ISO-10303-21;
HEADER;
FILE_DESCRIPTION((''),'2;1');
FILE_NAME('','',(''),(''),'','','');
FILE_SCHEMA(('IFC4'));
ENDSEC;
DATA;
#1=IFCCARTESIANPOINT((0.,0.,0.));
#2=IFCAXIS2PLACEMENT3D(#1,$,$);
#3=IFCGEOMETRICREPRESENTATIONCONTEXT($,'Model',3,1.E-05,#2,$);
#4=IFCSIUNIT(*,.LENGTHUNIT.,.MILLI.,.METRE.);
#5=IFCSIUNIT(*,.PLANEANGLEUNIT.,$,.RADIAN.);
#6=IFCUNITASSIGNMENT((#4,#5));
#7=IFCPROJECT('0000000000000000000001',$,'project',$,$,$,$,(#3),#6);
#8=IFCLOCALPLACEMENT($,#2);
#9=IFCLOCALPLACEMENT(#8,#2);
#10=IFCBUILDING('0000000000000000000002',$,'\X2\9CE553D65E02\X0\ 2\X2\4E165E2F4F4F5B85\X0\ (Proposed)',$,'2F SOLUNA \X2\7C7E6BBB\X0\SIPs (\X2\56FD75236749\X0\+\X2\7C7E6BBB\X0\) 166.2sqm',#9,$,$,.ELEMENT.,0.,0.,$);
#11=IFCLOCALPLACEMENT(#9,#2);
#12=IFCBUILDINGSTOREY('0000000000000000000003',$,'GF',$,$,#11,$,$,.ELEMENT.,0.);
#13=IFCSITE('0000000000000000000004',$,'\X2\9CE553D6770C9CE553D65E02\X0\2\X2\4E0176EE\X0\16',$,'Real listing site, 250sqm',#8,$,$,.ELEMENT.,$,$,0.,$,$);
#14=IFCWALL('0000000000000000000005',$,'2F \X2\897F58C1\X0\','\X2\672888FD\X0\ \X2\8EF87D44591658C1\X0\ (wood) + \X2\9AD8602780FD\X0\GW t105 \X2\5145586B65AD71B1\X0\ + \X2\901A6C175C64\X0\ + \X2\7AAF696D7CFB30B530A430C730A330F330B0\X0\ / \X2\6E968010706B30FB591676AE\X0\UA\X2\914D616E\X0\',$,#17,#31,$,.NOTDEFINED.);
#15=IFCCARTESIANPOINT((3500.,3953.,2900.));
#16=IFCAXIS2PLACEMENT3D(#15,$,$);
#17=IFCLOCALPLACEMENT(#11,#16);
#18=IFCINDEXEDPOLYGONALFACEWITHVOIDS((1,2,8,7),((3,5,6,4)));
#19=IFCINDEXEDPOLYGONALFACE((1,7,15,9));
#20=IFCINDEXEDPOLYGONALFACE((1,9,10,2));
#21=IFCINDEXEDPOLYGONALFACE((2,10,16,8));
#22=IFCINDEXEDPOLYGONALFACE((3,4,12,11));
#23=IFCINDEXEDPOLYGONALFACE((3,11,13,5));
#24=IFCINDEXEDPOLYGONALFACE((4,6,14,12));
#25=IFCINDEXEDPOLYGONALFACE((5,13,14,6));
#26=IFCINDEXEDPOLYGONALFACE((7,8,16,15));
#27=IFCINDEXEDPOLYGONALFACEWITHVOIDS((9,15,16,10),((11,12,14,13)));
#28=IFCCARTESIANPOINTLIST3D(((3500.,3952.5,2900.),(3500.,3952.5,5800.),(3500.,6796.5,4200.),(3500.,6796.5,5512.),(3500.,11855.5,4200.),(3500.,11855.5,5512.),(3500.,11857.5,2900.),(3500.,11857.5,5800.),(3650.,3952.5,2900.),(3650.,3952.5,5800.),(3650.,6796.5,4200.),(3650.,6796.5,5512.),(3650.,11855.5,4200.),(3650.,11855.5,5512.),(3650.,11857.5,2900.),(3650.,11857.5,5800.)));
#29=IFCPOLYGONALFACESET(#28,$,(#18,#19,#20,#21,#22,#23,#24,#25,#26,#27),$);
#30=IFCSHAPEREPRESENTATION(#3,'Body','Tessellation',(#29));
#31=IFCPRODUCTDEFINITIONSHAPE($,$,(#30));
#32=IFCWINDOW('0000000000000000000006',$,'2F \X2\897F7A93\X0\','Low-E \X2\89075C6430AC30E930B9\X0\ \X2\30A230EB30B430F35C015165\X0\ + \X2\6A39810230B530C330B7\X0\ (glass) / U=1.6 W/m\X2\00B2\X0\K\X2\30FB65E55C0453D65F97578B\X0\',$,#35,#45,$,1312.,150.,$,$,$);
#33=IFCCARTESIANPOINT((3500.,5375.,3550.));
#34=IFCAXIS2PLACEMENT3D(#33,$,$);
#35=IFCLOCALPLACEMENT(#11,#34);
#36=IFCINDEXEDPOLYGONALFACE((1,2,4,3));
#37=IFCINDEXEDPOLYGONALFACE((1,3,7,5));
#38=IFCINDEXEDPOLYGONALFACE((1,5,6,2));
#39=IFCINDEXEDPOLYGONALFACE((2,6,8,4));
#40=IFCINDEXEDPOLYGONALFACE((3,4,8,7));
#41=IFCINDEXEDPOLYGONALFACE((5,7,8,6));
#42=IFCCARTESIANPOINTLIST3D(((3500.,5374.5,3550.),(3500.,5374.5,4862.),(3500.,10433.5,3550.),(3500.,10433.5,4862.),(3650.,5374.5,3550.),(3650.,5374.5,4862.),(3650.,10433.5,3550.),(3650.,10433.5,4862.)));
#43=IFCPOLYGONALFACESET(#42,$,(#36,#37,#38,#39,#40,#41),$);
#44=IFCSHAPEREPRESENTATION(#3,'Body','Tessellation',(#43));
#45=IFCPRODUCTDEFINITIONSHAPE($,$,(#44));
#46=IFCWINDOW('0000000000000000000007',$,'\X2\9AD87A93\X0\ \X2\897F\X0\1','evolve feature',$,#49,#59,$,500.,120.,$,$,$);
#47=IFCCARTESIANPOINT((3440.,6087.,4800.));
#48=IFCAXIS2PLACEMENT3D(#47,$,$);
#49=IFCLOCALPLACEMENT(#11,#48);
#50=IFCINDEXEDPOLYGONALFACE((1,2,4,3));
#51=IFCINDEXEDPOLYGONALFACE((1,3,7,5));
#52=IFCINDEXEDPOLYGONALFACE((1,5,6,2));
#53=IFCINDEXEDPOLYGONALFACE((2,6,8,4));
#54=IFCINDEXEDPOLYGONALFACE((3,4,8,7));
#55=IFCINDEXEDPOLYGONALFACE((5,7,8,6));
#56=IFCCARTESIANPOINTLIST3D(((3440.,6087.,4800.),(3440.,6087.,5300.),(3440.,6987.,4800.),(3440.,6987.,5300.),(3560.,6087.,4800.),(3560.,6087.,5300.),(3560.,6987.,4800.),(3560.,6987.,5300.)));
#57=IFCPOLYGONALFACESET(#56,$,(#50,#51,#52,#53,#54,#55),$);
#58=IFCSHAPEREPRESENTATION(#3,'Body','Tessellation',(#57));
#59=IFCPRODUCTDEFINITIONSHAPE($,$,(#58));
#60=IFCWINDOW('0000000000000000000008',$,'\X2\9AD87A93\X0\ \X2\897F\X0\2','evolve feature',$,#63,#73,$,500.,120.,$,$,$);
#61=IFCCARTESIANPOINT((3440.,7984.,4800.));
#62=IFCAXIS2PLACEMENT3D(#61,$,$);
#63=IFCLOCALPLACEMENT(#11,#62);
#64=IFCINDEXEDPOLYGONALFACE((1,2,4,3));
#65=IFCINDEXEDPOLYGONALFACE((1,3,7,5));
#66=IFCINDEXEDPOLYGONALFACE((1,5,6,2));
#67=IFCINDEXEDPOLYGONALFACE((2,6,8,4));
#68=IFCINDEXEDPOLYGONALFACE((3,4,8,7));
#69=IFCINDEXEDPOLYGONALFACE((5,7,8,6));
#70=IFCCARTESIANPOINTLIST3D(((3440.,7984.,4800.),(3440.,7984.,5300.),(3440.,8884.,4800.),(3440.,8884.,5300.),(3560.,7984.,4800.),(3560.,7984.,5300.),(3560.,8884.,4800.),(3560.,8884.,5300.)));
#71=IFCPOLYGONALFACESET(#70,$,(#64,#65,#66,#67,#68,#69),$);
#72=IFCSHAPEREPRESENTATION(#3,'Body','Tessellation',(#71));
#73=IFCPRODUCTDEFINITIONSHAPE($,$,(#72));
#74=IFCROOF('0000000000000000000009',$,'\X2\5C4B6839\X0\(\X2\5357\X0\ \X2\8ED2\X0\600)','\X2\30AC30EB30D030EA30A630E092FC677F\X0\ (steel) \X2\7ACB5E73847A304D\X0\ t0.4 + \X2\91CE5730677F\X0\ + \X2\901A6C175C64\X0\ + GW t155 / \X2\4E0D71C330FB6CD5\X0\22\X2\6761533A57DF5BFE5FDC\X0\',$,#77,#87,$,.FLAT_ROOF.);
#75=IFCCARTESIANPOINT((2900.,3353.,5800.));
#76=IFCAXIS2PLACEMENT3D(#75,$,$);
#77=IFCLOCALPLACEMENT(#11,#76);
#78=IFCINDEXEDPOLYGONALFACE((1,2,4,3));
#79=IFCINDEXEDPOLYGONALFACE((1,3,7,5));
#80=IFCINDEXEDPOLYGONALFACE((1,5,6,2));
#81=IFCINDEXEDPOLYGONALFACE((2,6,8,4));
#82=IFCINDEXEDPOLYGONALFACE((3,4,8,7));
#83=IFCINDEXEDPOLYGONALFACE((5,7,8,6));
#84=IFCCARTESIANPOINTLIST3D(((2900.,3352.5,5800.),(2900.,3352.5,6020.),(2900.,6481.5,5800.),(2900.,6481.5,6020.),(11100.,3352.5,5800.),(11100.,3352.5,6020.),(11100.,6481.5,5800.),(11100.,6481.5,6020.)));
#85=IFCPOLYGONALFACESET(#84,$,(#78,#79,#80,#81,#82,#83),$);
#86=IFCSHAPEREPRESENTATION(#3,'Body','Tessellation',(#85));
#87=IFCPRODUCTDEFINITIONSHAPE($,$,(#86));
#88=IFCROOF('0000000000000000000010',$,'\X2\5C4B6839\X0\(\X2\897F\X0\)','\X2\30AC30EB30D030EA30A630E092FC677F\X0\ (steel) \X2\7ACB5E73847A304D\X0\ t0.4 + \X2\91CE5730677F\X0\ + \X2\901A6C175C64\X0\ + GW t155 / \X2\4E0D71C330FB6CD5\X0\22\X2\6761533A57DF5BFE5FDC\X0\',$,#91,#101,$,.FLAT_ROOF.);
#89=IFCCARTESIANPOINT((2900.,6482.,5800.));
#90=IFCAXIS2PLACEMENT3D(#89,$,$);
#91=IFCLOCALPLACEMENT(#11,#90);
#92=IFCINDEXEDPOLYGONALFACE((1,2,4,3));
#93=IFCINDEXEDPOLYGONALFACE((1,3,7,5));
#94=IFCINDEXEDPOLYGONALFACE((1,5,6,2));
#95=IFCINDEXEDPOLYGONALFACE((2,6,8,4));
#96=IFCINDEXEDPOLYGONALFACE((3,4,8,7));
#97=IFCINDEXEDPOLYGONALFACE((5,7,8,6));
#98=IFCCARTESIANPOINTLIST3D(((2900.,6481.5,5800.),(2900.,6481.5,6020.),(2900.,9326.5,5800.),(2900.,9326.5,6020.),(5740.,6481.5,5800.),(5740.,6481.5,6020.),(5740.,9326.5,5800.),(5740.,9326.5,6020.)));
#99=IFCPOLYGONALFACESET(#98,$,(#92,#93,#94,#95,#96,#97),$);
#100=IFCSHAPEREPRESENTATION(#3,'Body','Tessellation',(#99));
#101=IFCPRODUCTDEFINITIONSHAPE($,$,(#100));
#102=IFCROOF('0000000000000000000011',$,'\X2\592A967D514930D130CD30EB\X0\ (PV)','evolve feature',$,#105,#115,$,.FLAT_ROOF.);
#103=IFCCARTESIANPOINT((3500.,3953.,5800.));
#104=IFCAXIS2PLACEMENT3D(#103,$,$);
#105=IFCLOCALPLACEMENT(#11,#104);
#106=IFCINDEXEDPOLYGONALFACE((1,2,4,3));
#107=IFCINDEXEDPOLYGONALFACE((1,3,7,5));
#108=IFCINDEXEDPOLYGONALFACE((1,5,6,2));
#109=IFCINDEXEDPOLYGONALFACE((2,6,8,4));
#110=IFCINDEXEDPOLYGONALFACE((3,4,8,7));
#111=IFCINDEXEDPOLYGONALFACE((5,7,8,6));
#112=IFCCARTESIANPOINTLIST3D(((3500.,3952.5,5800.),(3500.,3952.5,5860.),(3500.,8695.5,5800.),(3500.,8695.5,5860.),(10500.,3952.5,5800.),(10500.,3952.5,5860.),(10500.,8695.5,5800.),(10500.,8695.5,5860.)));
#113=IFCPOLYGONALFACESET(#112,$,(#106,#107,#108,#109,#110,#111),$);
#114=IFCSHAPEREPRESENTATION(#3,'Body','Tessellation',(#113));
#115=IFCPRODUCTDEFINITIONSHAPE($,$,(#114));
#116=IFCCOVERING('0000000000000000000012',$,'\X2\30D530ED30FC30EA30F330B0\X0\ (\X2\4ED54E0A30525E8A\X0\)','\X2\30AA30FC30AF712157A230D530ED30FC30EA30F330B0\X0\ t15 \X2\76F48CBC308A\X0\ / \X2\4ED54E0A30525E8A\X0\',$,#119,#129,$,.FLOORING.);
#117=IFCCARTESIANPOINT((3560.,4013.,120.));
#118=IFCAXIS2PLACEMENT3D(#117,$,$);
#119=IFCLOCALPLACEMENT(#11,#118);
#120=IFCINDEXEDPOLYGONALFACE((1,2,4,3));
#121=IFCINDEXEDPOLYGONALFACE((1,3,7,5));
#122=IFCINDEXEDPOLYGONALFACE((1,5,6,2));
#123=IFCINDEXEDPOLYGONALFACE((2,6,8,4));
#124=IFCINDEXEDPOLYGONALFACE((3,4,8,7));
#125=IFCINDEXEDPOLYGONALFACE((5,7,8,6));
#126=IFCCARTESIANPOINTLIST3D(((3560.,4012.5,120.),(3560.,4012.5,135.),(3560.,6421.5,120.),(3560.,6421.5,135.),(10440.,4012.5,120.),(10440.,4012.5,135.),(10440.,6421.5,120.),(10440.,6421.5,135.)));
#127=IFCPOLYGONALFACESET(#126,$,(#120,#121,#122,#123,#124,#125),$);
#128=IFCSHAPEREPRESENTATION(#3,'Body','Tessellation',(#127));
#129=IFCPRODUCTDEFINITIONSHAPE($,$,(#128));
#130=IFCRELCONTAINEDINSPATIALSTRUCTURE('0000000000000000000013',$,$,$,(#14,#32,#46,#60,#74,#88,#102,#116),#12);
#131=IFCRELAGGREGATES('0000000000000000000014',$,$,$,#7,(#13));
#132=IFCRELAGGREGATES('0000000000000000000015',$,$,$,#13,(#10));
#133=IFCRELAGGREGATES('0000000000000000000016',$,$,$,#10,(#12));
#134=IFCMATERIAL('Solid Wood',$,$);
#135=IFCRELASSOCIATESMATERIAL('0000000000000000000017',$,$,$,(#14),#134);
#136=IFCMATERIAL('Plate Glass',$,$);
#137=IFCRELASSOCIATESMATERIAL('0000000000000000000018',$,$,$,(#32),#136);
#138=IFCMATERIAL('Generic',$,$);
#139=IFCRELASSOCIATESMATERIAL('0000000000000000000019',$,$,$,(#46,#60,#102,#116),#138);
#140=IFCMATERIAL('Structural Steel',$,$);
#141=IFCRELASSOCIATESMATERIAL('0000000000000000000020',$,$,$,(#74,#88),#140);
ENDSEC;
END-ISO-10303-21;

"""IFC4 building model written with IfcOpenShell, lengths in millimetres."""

from ifc_helpers import new_model, si_unit, frame, frame_2d, origin, place, context, project, spatial, rectangle, extrude, material, element, fill, save


model = new_model("IFC4")

# Units and contexts
model_context = context("Model", 3, precision=1e-05, world=origin())
ifc_project = project(units=[si_unit("LENGTHUNIT", "METRE", prefix="MILLI"), si_unit("PLANEANGLEUNIT", "RADIAN")], contexts=[model_context])

# Site, building, storey
site_placement = place(None, origin())
site = spatial("IfcSite", under=ifc_project, at=site_placement, Name="鳥取県鳥取市2丁目16", ObjectType="Real listing site, 250sqm", CompositionType="ELEMENT", RefElevation=0.0)
building_placement = place(site_placement, origin())
building = spatial("IfcBuilding", under=site, at=building_placement, Name="鳥取市 2世帯住宅 (Proposed)", ObjectType="2F SOLUNA 籾殻SIPs (国産杉+籾殻) 166.2sqm", CompositionType="ELEMENT", ElevationOfRefHeight=0.0, ElevationOfTerrain=0.0)
storey_placement = place(building_placement, origin())
storey = spatial("IfcBuildingStorey", under=building, at=storey_placement, Name="GF", CompositionType="ELEMENT", Elevation=0.0)

# Shared definitions
ifc_material_1 = material(Name="Solid Wood")
ifc_material_2 = material(Name="Generic")

# Shared definitions
ifc_material_3 = material(Name="Plate Glass")

# Wall, openings, windows
wall_1_placement = place(storey_placement, frame((3500.0, 3953.0, 2900.0)))
wall_1 = element("IfcWall", 1, at=wall_1_placement, inside=storey, material=ifc_material_1, Name="2F 西壁", Description="木製 軸組外壁 (wood) + 高性能GW t105 充填断熱 + 通気層 + 窯業系サイディング / 準耐火・外皮UA配慮", PredefinedType="NOTDEFINED", context=model_context, shape_type="SweptSolid", body=[
    extrude(rectangle(XDim=150.0, YDim=7905.0, at=frame_2d((75.0, 3952.0))), frame((3500.0, 3953.0, 2900.0)), (0.0, 0.0, 1.0), 2900.0),
])
opening_1_placement = place(storey_placement, frame((3500.0, 5375.0, 3550.0)))
opening_1 = element("IfcOpeningElement", 2, at=opening_1_placement, cuts=wall_1, PredefinedType="NOTDEFINED", context=model_context, shape_type="SweptSolid", body=[
    extrude(rectangle(XDim=150.0, YDim=5059.0, at=frame_2d((75.0, 2529.0))), frame((3500.0, 5375.0, 3550.0)), (0.0, 0.0, 1.0), 1312.0),
])
opening_2_placement = place(storey_placement, frame((3440.0, 6087.0, 4800.0)))
opening_2 = element("IfcOpeningElement", 3, at=opening_2_placement, cuts=wall_1, PredefinedType="NOTDEFINED", context=model_context, shape_type="SweptSolid", body=[
    extrude(rectangle(XDim=120.0, YDim=900.0, at=frame_2d((60.0, 450.0))), frame((3440.0, 6087.0, 4800.0)), (0.0, 0.0, 1.0), 500.0),
])
opening_3_placement = place(storey_placement, frame((3440.0, 7984.0, 4800.0)))
opening_3 = element("IfcOpeningElement", 4, at=opening_3_placement, cuts=wall_1, PredefinedType="NOTDEFINED", context=model_context, shape_type="SweptSolid", body=[
    extrude(rectangle(XDim=120.0, YDim=900.0, at=frame_2d((60.0, 450.0))), frame((3440.0, 7984.0, 4800.0)), (0.0, 0.0, 1.0), 500.0),
])
window_1_placement = place(storey_placement, frame((3500.0, 5375.0, 3550.0)))
window_1 = element("IfcWindow", 5, at=window_1_placement, inside=storey, material=ifc_material_3, Name="2F 西窓", Description="Low-E 複層ガラス アルゴン封入 + 樹脂サッシ (glass) / U=1.6 W/m²K・日射取得型", OverallHeight=1312.0, OverallWidth=150.0, context=model_context, shape_type="SweptSolid", body=[
    extrude(rectangle(XDim=150.0, YDim=5059.0, at=frame_2d((75.0, 2529.0))), frame((3500.0, 5375.0, 3550.0)), (0.0, 0.0, 1.0), 1312.0),
])
fill(opening_1, window_1)
window_2_placement = place(storey_placement, frame((3440.0, 6087.0, 4800.0)))
window_2 = element("IfcWindow", 6, at=window_2_placement, inside=storey, material=ifc_material_2, Name="高窓 西1", Description="evolve feature", OverallHeight=500.0, OverallWidth=120.0, context=model_context, shape_type="SweptSolid", body=[
    extrude(rectangle(XDim=120.0, YDim=900.0, at=frame_2d((60.0, 450.0))), frame((3440.0, 6087.0, 4800.0)), (0.0, 0.0, 1.0), 500.0),
])
fill(opening_2, window_2)
window_3_placement = place(storey_placement, frame((3440.0, 7984.0, 4800.0)))
window_3 = element("IfcWindow", 7, at=window_3_placement, inside=storey, material=ifc_material_2, Name="高窓 西2", Description="evolve feature", OverallHeight=500.0, OverallWidth=120.0, context=model_context, shape_type="SweptSolid", body=[
    extrude(rectangle(XDim=120.0, YDim=900.0, at=frame_2d((60.0, 450.0))), frame((3440.0, 7984.0, 4800.0)), (0.0, 0.0, 1.0), 500.0),
])
fill(opening_3, window_3)

# Roofs
ifc_material_4 = material(Name="Structural Steel")
roof_1_placement = place(storey_placement, frame((2900.0, 3353.0, 5800.0)))
element("IfcRoof", 8, at=roof_1_placement, inside=storey, material=ifc_material_4, Name="屋根(南 軒600)", Description="ガルバリウム鋼板 (steel) 立平葺き t0.4 + 野地板 + 通気層 + GW t155 / 不燃・法22条区域対応", PredefinedType="FLAT_ROOF", context=model_context, shape_type="SweptSolid", body=[
    extrude(rectangle(XDim=8200.0, YDim=3129.0, at=frame_2d((4100.0, 1564.0))), frame((2900.0, 3353.0, 5800.0)), (0.0, 0.0, 1.0), 220.0),
])
roof_2_placement = place(storey_placement, frame((2900.0, 6482.0, 5800.0)))
element("IfcRoof", 9, at=roof_2_placement, inside=storey, material=ifc_material_4, Name="屋根(西)", Description="ガルバリウム鋼板 (steel) 立平葺き t0.4 + 野地板 + 通気層 + GW t155 / 不燃・法22条区域対応", PredefinedType="FLAT_ROOF", context=model_context, shape_type="SweptSolid", body=[
    extrude(rectangle(XDim=2840.0, YDim=2845.0, at=frame_2d((1420.0, 1422.0))), frame((2900.0, 6482.0, 5800.0)), (0.0, 0.0, 1.0), 220.0),
])
roof_3_placement = place(storey_placement, frame((3500.0, 3953.0, 5800.0)))
element("IfcRoof", 10, at=roof_3_placement, inside=storey, material=ifc_material_2, Name="太陽光パネル (PV)", Description="evolve feature", PredefinedType="FLAT_ROOF", context=model_context, shape_type="SweptSolid", body=[
    extrude(rectangle(XDim=7000.0, YDim=4743.0, at=frame_2d((3500.0, 2371.0))), frame((3500.0, 3953.0, 5800.0)), (0.0, 0.0, 1.0), 60.0),
])

# Covering
covering_placement = place(storey_placement, frame((3560.0, 4013.0, 120.0)))
element("IfcCovering", 11, at=covering_placement, inside=storey, material=ifc_material_2, Name="フローリング (仕上げ床)", Description="オーク無垢フローリング t15 直貼り / 仕上げ床", PredefinedType="FLOORING", context=model_context, shape_type="SweptSolid", body=[
    extrude(rectangle(XDim=6880.0, YDim=2409.0, at=frame_2d((3440.0, 1204.0))), frame((3560.0, 4013.0, 120.0)), (0.0, 0.0, 1.0), 15.0),
])

save(model, "model.ifc")
